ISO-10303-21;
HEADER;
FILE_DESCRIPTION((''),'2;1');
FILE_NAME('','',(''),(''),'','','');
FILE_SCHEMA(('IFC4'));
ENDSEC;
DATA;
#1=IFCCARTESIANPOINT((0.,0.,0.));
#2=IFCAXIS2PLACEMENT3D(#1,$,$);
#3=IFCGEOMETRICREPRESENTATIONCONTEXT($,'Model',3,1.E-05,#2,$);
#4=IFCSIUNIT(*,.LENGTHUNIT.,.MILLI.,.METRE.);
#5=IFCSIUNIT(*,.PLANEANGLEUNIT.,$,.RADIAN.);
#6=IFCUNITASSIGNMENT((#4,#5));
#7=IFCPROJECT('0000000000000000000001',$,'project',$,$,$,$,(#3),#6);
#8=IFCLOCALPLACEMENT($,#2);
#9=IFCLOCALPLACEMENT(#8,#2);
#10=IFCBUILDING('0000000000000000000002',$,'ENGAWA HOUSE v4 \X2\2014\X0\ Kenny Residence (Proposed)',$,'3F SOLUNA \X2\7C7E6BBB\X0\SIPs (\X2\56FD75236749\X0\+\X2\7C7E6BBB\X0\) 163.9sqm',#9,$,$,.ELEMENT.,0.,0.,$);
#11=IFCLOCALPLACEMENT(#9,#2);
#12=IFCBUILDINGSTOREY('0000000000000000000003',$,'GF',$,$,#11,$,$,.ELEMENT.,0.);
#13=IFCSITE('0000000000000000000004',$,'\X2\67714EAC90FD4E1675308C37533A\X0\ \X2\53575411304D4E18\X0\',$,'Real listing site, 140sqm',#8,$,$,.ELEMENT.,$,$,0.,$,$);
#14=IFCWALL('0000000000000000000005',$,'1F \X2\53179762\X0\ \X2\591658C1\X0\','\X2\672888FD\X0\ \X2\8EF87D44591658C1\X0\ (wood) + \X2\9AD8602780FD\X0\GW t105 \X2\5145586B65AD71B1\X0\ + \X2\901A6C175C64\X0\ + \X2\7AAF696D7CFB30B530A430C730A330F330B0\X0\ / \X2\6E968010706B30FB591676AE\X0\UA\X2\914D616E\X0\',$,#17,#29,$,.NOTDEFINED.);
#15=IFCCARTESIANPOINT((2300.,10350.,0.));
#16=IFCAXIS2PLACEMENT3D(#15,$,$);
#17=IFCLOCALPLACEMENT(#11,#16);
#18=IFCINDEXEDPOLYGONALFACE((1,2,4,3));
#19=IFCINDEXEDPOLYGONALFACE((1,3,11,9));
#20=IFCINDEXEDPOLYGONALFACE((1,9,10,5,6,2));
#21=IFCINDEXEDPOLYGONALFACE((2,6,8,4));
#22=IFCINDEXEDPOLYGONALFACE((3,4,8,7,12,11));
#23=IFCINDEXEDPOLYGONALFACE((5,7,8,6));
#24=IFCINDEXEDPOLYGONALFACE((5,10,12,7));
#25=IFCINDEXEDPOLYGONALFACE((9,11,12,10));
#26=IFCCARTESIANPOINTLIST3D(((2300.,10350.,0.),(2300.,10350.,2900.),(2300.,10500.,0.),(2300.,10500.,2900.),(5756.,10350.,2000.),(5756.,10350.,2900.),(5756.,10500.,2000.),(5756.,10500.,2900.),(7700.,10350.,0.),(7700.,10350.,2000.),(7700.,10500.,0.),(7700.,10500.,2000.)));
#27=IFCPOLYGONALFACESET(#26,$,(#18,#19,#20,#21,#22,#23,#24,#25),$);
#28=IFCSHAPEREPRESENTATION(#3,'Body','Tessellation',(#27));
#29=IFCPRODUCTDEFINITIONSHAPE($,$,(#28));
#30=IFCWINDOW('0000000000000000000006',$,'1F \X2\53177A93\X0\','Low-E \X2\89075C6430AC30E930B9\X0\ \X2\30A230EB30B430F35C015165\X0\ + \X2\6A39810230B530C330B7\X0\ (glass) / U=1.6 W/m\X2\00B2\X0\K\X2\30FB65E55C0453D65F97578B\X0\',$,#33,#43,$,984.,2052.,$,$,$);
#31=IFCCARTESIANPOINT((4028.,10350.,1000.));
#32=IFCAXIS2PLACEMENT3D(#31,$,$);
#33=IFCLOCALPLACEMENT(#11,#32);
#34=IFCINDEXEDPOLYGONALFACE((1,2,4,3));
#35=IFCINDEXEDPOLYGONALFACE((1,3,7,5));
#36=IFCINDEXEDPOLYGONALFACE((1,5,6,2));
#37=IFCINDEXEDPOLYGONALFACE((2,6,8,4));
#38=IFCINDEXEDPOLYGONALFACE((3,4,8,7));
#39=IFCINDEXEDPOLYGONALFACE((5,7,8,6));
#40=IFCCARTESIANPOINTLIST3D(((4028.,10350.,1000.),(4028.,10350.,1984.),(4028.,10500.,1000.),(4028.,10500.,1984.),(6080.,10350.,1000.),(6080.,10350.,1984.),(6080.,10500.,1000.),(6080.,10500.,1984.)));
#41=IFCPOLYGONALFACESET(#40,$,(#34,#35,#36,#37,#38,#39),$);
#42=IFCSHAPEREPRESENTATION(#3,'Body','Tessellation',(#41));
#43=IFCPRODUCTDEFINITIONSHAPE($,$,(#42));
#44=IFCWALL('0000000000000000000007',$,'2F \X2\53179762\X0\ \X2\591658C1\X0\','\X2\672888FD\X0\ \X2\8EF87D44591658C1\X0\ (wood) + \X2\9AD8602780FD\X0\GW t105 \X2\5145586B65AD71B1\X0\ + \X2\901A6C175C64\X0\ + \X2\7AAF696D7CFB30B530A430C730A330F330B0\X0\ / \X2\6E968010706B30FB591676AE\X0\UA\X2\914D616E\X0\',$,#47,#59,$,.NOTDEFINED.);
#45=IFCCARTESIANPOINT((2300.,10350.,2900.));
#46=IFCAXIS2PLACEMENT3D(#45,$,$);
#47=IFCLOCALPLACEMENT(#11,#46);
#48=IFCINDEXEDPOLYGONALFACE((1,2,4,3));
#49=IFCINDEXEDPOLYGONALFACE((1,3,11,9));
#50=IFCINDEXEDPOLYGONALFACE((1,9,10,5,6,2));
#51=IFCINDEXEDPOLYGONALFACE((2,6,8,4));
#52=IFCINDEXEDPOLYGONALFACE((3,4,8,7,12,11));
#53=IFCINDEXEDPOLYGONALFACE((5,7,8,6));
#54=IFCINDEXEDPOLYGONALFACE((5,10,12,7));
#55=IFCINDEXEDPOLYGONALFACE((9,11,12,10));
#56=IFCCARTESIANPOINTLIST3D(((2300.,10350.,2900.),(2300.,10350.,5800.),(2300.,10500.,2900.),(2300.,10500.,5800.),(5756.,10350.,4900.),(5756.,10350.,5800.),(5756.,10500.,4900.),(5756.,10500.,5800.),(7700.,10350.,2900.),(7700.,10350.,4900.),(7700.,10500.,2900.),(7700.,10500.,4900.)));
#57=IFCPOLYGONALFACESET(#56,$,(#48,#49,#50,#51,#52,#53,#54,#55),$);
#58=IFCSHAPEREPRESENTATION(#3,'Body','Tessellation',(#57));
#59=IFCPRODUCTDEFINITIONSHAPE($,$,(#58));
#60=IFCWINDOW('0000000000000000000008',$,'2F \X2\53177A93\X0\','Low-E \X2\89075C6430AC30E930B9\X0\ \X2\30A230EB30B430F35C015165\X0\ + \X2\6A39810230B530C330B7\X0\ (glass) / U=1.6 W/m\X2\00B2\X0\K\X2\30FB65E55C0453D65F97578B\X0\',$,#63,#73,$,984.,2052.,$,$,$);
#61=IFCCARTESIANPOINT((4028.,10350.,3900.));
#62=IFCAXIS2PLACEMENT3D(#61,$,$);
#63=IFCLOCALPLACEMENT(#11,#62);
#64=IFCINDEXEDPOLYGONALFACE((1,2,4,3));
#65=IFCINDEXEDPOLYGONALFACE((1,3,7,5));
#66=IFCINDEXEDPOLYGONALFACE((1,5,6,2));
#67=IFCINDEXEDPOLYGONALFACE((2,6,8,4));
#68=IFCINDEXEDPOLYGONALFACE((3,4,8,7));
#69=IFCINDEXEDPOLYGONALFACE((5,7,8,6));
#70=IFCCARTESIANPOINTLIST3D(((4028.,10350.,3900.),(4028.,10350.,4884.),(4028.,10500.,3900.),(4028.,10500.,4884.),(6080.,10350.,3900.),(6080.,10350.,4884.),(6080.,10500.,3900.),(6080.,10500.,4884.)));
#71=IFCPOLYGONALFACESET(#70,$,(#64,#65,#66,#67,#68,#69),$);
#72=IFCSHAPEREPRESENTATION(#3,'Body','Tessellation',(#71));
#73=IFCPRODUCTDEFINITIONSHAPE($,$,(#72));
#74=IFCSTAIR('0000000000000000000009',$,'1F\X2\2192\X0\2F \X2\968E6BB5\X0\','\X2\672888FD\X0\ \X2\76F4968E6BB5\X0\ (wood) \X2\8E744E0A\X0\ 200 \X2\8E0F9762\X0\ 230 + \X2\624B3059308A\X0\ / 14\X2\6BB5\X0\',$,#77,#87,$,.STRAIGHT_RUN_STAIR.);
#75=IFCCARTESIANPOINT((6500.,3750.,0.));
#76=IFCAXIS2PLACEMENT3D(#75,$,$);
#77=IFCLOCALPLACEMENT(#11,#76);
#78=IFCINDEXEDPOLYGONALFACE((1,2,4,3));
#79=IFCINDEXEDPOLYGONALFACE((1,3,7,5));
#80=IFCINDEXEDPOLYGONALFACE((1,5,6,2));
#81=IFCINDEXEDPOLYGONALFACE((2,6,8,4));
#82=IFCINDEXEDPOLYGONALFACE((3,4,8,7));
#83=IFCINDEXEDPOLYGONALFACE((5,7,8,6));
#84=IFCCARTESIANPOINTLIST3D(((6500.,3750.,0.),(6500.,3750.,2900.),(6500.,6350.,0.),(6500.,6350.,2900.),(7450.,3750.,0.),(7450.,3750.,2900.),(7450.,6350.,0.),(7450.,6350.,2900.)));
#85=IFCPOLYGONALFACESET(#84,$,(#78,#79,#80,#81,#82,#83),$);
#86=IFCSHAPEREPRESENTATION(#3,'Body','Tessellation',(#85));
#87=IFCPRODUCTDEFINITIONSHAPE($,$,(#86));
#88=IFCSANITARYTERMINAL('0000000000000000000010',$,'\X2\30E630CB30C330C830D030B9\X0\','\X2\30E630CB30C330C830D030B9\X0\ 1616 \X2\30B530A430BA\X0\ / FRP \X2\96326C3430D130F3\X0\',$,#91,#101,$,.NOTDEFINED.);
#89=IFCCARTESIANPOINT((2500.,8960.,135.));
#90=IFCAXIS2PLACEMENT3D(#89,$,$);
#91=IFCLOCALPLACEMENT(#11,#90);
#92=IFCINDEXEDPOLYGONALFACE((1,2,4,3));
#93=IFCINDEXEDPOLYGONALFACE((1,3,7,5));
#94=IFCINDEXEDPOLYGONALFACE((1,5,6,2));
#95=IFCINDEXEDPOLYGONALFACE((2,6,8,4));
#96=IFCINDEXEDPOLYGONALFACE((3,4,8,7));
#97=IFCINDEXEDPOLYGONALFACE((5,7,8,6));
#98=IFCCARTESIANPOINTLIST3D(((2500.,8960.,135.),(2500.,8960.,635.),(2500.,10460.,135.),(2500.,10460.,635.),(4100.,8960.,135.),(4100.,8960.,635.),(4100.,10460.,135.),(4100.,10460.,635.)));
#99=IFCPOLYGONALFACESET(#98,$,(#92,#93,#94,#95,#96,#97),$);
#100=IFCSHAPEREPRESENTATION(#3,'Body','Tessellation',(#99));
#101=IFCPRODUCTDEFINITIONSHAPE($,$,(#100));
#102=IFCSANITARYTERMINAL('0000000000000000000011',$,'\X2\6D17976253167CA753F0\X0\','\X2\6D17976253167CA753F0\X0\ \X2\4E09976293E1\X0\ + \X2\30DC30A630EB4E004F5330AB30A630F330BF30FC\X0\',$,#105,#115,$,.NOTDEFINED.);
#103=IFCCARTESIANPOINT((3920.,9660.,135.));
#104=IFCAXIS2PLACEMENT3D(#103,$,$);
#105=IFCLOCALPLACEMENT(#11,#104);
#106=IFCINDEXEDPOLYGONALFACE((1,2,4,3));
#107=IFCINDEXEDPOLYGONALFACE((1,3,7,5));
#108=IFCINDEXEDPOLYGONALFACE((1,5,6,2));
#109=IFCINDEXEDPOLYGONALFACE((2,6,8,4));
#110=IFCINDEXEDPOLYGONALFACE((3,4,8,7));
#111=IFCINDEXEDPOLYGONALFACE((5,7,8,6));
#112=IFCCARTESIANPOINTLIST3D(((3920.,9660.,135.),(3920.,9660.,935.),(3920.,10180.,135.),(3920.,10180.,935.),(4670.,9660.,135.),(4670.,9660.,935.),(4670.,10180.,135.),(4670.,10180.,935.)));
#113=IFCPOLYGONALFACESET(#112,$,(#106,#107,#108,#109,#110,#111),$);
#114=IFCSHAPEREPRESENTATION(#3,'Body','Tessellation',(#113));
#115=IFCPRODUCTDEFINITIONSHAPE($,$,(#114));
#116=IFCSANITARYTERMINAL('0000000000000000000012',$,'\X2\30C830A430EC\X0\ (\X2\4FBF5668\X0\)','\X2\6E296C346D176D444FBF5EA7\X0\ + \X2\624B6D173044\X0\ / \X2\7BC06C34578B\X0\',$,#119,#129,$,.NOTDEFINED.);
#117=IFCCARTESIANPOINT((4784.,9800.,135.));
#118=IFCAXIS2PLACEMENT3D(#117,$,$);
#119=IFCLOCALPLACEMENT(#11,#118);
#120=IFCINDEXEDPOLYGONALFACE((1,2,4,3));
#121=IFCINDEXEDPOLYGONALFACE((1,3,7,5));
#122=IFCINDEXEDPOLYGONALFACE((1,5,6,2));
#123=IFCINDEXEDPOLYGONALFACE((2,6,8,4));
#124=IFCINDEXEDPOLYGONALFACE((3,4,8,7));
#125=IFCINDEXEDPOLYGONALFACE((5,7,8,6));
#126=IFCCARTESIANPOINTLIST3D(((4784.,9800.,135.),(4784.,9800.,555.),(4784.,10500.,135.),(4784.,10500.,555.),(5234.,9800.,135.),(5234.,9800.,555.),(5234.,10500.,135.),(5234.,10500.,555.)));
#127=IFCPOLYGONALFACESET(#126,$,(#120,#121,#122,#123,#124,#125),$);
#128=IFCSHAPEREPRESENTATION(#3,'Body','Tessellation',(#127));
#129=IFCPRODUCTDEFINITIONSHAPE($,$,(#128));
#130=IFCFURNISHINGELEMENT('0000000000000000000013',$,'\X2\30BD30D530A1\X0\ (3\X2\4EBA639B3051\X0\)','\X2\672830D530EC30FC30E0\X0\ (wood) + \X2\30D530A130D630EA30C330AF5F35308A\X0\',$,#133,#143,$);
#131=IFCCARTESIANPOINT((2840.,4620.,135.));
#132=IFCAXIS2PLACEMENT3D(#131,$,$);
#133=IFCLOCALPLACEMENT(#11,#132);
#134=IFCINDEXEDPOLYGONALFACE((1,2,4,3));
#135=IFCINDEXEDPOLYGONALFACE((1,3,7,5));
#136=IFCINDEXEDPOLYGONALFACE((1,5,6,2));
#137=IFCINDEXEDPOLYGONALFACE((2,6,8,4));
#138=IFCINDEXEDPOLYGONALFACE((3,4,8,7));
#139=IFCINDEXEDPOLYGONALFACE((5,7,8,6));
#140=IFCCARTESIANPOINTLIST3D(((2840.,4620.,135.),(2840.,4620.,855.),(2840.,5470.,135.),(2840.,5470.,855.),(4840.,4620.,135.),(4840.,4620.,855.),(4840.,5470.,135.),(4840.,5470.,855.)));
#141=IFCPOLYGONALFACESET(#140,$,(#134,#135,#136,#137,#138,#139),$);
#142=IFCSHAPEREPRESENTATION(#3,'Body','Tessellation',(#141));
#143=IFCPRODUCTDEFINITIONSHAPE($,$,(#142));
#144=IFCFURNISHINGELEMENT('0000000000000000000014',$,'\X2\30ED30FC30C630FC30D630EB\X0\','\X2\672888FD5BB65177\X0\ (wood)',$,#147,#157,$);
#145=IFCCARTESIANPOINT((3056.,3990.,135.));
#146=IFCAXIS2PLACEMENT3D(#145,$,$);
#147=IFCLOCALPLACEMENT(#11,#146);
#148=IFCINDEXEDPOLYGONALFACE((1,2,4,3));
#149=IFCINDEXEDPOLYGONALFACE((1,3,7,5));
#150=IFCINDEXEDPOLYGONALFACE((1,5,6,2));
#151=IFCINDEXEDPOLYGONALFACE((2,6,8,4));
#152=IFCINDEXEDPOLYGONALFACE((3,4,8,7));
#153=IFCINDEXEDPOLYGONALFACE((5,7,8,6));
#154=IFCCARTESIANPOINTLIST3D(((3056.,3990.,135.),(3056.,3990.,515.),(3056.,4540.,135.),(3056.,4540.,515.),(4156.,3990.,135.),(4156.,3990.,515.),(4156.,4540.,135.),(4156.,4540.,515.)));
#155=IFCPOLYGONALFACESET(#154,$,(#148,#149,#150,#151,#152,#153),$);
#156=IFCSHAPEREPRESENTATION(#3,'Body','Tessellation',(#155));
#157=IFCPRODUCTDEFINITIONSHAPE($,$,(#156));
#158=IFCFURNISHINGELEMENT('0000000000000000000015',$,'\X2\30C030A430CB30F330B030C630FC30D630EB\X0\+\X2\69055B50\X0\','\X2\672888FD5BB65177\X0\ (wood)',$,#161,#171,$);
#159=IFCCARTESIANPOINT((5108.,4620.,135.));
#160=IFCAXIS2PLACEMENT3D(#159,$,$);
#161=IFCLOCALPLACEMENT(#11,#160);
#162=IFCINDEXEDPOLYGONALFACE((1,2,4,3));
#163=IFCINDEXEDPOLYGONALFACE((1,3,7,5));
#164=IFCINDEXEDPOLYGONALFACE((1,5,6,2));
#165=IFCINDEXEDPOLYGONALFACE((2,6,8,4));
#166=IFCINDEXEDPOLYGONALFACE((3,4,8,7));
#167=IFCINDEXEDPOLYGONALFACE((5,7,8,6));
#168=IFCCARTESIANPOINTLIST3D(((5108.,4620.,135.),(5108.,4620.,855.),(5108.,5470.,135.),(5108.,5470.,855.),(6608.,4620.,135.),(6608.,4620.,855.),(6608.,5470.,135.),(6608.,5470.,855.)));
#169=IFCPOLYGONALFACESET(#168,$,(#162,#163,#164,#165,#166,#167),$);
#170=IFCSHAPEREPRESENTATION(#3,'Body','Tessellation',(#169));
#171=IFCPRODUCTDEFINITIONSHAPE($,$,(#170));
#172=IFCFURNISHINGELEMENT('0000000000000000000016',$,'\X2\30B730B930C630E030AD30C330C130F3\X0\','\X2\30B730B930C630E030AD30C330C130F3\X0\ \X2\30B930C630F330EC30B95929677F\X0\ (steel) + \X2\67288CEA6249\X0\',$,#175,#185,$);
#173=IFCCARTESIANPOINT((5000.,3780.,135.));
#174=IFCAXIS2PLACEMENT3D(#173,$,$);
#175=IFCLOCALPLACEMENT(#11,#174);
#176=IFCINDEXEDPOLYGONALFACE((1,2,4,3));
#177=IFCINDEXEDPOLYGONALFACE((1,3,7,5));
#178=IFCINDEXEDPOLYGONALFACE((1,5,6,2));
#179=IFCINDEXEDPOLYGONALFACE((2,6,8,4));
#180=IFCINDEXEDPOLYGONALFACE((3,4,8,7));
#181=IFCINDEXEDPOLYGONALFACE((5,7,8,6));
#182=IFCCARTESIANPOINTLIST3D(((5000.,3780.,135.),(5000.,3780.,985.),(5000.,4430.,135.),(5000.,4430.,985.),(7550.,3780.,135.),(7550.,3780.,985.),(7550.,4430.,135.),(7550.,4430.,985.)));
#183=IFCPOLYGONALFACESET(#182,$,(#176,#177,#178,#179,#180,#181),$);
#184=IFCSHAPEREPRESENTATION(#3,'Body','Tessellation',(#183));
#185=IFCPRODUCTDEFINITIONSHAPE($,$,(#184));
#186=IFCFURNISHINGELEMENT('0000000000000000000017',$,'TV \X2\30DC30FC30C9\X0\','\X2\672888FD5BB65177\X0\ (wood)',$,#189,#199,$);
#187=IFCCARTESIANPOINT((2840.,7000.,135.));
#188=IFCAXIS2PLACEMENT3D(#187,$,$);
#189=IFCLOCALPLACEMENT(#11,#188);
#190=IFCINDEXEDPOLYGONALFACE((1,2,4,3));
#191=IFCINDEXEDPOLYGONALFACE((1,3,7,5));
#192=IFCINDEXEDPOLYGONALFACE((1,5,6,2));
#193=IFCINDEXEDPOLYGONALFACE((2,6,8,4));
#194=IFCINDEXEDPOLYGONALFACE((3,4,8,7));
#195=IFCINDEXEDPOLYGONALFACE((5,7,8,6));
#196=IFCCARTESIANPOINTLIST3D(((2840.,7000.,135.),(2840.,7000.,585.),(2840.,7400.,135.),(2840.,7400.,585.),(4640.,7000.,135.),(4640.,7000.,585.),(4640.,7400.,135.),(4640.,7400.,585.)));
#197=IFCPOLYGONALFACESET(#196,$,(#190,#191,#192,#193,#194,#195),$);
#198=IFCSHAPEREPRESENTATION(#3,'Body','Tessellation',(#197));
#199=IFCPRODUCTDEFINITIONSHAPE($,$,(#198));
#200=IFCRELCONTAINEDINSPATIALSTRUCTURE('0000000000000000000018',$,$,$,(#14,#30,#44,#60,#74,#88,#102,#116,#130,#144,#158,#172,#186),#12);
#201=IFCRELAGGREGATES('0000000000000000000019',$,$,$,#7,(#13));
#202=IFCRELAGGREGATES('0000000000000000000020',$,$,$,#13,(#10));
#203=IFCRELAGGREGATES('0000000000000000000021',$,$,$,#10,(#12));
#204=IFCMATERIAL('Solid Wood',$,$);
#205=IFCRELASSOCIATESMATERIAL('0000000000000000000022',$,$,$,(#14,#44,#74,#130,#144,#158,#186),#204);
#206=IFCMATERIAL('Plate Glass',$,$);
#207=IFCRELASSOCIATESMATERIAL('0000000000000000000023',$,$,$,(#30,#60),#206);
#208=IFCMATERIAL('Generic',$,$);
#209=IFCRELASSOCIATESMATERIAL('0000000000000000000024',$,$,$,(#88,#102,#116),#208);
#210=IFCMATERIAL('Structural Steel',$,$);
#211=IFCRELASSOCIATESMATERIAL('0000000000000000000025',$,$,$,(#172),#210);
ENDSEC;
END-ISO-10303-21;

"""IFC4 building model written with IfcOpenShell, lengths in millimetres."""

from ifc_helpers import new_model, si_unit, frame, frame_2d, origin, place, context, project, spatial, rectangle, extrude, material, element, fill, save


model = new_model("IFC4")

# Units and contexts
model_context = context("Model", 3, precision=1e-05, world=origin())
ifc_project = project(units=[si_unit("LENGTHUNIT", "METRE", prefix="MILLI"), si_unit("PLANEANGLEUNIT", "RADIAN")], contexts=[model_context])

# Site, building, storey
site_placement = place(None, origin())
site = spatial("IfcSite", under=ifc_project, at=site_placement, Name="東京都世田谷区 南向き丘", ObjectType="Real listing site, 140sqm", CompositionType="ELEMENT", RefElevation=0.0)
building_placement = place(site_placement, origin())
building = spatial("IfcBuilding", under=site, at=building_placement, Name="ENGAWA HOUSE v4 — Kenny Residence (Proposed)", ObjectType="3F SOLUNA 籾殻SIPs (国産杉+籾殻) 163.9sqm", CompositionType="ELEMENT", ElevationOfRefHeight=0.0, ElevationOfTerrain=0.0)
storey_placement = place(building_placement, origin())
storey = spatial("IfcBuildingStorey", under=building, at=storey_placement, Name="GF", CompositionType="ELEMENT", Elevation=0.0)

# Wall, opening, window
ifc_material_1 = material(Name="Solid Wood")
wall_1_placement = place(storey_placement, frame((2300.0, 10350.0, 0.0)))
wall_1 = element("IfcWall", 1, at=wall_1_placement, inside=storey, material=ifc_material_1, Name="1F 北面 外壁", Description="木製 軸組外壁 (wood) + 高性能GW t105 充填断熱 + 通気層 + 窯業系サイディング / 準耐火・外皮UA配慮", PredefinedType="NOTDEFINED", context=model_context, shape_type="SweptSolid", body=[
    extrude(rectangle(XDim=5400.0, YDim=150.0, at=frame_2d((2700.0, 75.0))), frame((2300.0, 10350.0, 0.0)), (0.0, 0.0, 1.0), 2900.0),
])
opening_1_placement = place(storey_placement, frame((4028.0, 10350.0, 1000.0)))
opening_1 = element("IfcOpeningElement", 2, at=opening_1_placement, cuts=wall_1, PredefinedType="NOTDEFINED", context=model_context, shape_type="SweptSolid", body=[
    extrude(rectangle(XDim=2052.0, YDim=150.0, at=frame_2d((1026.0, 75.0))), frame((4028.0, 10350.0, 1000.0)), (0.0, 0.0, 1.0), 984.0),
])
ifc_material_2 = material(Name="Plate Glass")
window_1_placement = place(storey_placement, frame((4028.0, 10350.0, 1000.0)))
window_1 = element("IfcWindow", 3, at=window_1_placement, inside=storey, material=ifc_material_2, Name="1F 北窓", Description="Low-E 複層ガラス アルゴン封入 + 樹脂サッシ (glass) / U=1.6 W/m²K・日射取得型", OverallHeight=984.0, OverallWidth=2052.0, context=model_context, shape_type="SweptSolid", body=[
    extrude(rectangle(XDim=2052.0, YDim=150.0, at=frame_2d((1026.0, 75.0))), frame((4028.0, 10350.0, 1000.0)), (0.0, 0.0, 1.0), 984.0),
])
fill(opening_1, window_1)

# Wall, opening, window
wall_2_placement = place(storey_placement, frame((2300.0, 10350.0, 2900.0)))
wall_2 = element("IfcWall", 4, at=wall_2_placement, inside=storey, material=ifc_material_1, Name="2F 北面 外壁", Description="木製 軸組外壁 (wood) + 高性能GW t105 充填断熱 + 通気層 + 窯業系サイディング / 準耐火・外皮UA配慮", PredefinedType="NOTDEFINED", context=model_context, shape_type="SweptSolid", body=[
    extrude(rectangle(XDim=5400.0, YDim=150.0, at=frame_2d((2700.0, 75.0))), frame((2300.0, 10350.0, 2900.0)), (0.0, 0.0, 1.0), 2900.0),
])
opening_2_placement = place(storey_placement, frame((4028.0, 10350.0, 3900.0)))
opening_2 = element("IfcOpeningElement", 5, at=opening_2_placement, cuts=wall_2, PredefinedType="NOTDEFINED", context=model_context, shape_type="SweptSolid", body=[
    extrude(rectangle(XDim=2052.0, YDim=150.0, at=frame_2d((1026.0, 75.0))), frame((4028.0, 10350.0, 3900.0)), (0.0, 0.0, 1.0), 984.0),
])
window_2_placement = place(storey_placement, frame((4028.0, 10350.0, 3900.0)))
window_2 = element("IfcWindow", 6, at=window_2_placement, inside=storey, material=ifc_material_2, Name="2F 北窓", Description="Low-E 複層ガラス アルゴン封入 + 樹脂サッシ (glass) / U=1.6 W/m²K・日射取得型", OverallHeight=984.0, OverallWidth=2052.0, context=model_context, shape_type="SweptSolid", body=[
    extrude(rectangle(XDim=2052.0, YDim=150.0, at=frame_2d((1026.0, 75.0))), frame((4028.0, 10350.0, 3900.0)), (0.0, 0.0, 1.0), 984.0),
])
fill(opening_2, window_2)

# Stair
stair_placement = place(storey_placement, frame((6500.0, 3750.0, 0.0)))
element("IfcStair", 7, at=stair_placement, inside=storey, material=ifc_material_1, Name="1F→2F 階段", Description="木製 直階段 (wood) 蹴上 200 踏面 230 + 手すり / 14段", PredefinedType="STRAIGHT_RUN_STAIR", context=model_context, shape_type="SweptSolid", body=[
    extrude(rectangle(XDim=950.0, YDim=2600.0, at=frame_2d((475.0, 1300.0))), frame((6500.0, 3750.0, 0.0)), (0.0, 0.0, 1.0), 2900.0),
])

# Sanitary terminals
ifc_material_3 = material(Name="Generic")
sanitary_terminal_1_placement = place(storey_placement, frame((2500.0, 8960.0, 135.0)))
element("IfcSanitaryTerminal", 8, at=sanitary_terminal_1_placement, inside=storey, material=ifc_material_3, Name="ユニットバス", Description="ユニットバス 1616 サイズ / FRP 防水パン", PredefinedType="NOTDEFINED", context=model_context, shape_type="SweptSolid", body=[
    extrude(rectangle(XDim=1600.0, YDim=1500.0, at=frame_2d((800.0, 750.0))), frame((2500.0, 8960.0, 135.0)), (0.0, 0.0, 1.0), 500.0),
])
sanitary_terminal_2_placement = place(storey_placement, frame((3920.0, 9660.0, 135.0)))
element("IfcSanitaryTerminal", 9, at=sanitary_terminal_2_placement, inside=storey, material=ifc_material_3, Name="洗面化粧台", Description="洗面化粧台 三面鏡 + ボウル一体カウンター", PredefinedType="NOTDEFINED", context=model_context, shape_type="SweptSolid", body=[
    extrude(rectangle(XDim=750.0, YDim=520.0, at=frame_2d((375.0, 260.0))), frame((3920.0, 9660.0, 135.0)), (0.0, 0.0, 1.0), 800.0),
])
sanitary_terminal_3_placement = place(storey_placement, frame((4784.0, 9800.0, 135.0)))
element("IfcSanitaryTerminal", 10, at=sanitary_terminal_3_placement, inside=storey, material=ifc_material_3, Name="トイレ (便器)", Description="温水洗浄便座 + 手洗い / 節水型", PredefinedType="NOTDEFINED", context=model_context, shape_type="SweptSolid", body=[
    extrude(rectangle(XDim=450.0, YDim=700.0, at=frame_2d((225.0, 350.0))), frame((4784.0, 9800.0, 135.0)), (0.0, 0.0, 1.0), 420.0),
])

# Furnishing elements
furnishing_1_placement = place(storey_placement, frame((2840.0, 4620.0, 135.0)))
element("IfcFurnishingElement", 11, at=furnishing_1_placement, inside=storey, material=ifc_material_1, Name="ソファ (3人掛け)", Description="木フレーム (wood) + ファブリック張り", context=model_context, shape_type="SweptSolid", body=[
    extrude(rectangle(XDim=2000.0, YDim=850.0, at=frame_2d((1000.0, 425.0))), frame((2840.0, 4620.0, 135.0)), (0.0, 0.0, 1.0), 720.0),
])
furnishing_2_placement = place(storey_placement, frame((3056.0, 3990.0, 135.0)))
element("IfcFurnishingElement", 12, at=furnishing_2_placement, inside=storey, material=ifc_material_1, Name="ローテーブル", Description="木製家具 (wood)", context=model_context, shape_type="SweptSolid", body=[
    extrude(rectangle(XDim=1100.0, YDim=550.0, at=frame_2d((550.0, 275.0))), frame((3056.0, 3990.0, 135.0)), (0.0, 0.0, 1.0), 380.0),
])
furnishing_3_placement = place(storey_placement, frame((5108.0, 4620.0, 135.0)))
element("IfcFurnishingElement", 13, at=furnishing_3_placement, inside=storey, material=ifc_material_1, Name="ダイニングテーブル+椅子", Description="木製家具 (wood)", context=model_context, shape_type="SweptSolid", body=[
    extrude(rectangle(XDim=1500.0, YDim=850.0, at=frame_2d((750.0, 425.0))), frame((5108.0, 4620.0, 135.0)), (0.0, 0.0, 1.0), 720.0),
])
ifc_material_4 = material(Name="Structural Steel")
furnishing_4_placement = place(storey_placement, frame((5000.0, 3780.0, 135.0)))
element("IfcFurnishingElement", 14, at=furnishing_4_placement, inside=storey, material=ifc_material_4, Name="システムキッチン", Description="システムキッチン ステンレス天板 (steel) + 木質扉", context=model_context, shape_type="SweptSolid", body=[
    extrude(rectangle(XDim=2550.0, YDim=650.0, at=frame_2d((1275.0, 325.0))), frame((5000.0, 3780.0, 135.0)), (0.0, 0.0, 1.0), 850.0),
])
furnishing_5_placement = place(storey_placement, frame((2840.0, 7000.0, 135.0)))
element("IfcFurnishingElement", 15, at=furnishing_5_placement, inside=storey, material=ifc_material_1, Name="TV ボード", Description="木製家具 (wood)", context=model_context, shape_type="SweptSolid", body=[
    extrude(rectangle(XDim=1800.0, YDim=400.0, at=frame_2d((900.0, 200.0))), frame((2840.0, 7000.0, 135.0)), (0.0, 0.0, 1.0), 450.0),
])

save(model, "model.ifc")
